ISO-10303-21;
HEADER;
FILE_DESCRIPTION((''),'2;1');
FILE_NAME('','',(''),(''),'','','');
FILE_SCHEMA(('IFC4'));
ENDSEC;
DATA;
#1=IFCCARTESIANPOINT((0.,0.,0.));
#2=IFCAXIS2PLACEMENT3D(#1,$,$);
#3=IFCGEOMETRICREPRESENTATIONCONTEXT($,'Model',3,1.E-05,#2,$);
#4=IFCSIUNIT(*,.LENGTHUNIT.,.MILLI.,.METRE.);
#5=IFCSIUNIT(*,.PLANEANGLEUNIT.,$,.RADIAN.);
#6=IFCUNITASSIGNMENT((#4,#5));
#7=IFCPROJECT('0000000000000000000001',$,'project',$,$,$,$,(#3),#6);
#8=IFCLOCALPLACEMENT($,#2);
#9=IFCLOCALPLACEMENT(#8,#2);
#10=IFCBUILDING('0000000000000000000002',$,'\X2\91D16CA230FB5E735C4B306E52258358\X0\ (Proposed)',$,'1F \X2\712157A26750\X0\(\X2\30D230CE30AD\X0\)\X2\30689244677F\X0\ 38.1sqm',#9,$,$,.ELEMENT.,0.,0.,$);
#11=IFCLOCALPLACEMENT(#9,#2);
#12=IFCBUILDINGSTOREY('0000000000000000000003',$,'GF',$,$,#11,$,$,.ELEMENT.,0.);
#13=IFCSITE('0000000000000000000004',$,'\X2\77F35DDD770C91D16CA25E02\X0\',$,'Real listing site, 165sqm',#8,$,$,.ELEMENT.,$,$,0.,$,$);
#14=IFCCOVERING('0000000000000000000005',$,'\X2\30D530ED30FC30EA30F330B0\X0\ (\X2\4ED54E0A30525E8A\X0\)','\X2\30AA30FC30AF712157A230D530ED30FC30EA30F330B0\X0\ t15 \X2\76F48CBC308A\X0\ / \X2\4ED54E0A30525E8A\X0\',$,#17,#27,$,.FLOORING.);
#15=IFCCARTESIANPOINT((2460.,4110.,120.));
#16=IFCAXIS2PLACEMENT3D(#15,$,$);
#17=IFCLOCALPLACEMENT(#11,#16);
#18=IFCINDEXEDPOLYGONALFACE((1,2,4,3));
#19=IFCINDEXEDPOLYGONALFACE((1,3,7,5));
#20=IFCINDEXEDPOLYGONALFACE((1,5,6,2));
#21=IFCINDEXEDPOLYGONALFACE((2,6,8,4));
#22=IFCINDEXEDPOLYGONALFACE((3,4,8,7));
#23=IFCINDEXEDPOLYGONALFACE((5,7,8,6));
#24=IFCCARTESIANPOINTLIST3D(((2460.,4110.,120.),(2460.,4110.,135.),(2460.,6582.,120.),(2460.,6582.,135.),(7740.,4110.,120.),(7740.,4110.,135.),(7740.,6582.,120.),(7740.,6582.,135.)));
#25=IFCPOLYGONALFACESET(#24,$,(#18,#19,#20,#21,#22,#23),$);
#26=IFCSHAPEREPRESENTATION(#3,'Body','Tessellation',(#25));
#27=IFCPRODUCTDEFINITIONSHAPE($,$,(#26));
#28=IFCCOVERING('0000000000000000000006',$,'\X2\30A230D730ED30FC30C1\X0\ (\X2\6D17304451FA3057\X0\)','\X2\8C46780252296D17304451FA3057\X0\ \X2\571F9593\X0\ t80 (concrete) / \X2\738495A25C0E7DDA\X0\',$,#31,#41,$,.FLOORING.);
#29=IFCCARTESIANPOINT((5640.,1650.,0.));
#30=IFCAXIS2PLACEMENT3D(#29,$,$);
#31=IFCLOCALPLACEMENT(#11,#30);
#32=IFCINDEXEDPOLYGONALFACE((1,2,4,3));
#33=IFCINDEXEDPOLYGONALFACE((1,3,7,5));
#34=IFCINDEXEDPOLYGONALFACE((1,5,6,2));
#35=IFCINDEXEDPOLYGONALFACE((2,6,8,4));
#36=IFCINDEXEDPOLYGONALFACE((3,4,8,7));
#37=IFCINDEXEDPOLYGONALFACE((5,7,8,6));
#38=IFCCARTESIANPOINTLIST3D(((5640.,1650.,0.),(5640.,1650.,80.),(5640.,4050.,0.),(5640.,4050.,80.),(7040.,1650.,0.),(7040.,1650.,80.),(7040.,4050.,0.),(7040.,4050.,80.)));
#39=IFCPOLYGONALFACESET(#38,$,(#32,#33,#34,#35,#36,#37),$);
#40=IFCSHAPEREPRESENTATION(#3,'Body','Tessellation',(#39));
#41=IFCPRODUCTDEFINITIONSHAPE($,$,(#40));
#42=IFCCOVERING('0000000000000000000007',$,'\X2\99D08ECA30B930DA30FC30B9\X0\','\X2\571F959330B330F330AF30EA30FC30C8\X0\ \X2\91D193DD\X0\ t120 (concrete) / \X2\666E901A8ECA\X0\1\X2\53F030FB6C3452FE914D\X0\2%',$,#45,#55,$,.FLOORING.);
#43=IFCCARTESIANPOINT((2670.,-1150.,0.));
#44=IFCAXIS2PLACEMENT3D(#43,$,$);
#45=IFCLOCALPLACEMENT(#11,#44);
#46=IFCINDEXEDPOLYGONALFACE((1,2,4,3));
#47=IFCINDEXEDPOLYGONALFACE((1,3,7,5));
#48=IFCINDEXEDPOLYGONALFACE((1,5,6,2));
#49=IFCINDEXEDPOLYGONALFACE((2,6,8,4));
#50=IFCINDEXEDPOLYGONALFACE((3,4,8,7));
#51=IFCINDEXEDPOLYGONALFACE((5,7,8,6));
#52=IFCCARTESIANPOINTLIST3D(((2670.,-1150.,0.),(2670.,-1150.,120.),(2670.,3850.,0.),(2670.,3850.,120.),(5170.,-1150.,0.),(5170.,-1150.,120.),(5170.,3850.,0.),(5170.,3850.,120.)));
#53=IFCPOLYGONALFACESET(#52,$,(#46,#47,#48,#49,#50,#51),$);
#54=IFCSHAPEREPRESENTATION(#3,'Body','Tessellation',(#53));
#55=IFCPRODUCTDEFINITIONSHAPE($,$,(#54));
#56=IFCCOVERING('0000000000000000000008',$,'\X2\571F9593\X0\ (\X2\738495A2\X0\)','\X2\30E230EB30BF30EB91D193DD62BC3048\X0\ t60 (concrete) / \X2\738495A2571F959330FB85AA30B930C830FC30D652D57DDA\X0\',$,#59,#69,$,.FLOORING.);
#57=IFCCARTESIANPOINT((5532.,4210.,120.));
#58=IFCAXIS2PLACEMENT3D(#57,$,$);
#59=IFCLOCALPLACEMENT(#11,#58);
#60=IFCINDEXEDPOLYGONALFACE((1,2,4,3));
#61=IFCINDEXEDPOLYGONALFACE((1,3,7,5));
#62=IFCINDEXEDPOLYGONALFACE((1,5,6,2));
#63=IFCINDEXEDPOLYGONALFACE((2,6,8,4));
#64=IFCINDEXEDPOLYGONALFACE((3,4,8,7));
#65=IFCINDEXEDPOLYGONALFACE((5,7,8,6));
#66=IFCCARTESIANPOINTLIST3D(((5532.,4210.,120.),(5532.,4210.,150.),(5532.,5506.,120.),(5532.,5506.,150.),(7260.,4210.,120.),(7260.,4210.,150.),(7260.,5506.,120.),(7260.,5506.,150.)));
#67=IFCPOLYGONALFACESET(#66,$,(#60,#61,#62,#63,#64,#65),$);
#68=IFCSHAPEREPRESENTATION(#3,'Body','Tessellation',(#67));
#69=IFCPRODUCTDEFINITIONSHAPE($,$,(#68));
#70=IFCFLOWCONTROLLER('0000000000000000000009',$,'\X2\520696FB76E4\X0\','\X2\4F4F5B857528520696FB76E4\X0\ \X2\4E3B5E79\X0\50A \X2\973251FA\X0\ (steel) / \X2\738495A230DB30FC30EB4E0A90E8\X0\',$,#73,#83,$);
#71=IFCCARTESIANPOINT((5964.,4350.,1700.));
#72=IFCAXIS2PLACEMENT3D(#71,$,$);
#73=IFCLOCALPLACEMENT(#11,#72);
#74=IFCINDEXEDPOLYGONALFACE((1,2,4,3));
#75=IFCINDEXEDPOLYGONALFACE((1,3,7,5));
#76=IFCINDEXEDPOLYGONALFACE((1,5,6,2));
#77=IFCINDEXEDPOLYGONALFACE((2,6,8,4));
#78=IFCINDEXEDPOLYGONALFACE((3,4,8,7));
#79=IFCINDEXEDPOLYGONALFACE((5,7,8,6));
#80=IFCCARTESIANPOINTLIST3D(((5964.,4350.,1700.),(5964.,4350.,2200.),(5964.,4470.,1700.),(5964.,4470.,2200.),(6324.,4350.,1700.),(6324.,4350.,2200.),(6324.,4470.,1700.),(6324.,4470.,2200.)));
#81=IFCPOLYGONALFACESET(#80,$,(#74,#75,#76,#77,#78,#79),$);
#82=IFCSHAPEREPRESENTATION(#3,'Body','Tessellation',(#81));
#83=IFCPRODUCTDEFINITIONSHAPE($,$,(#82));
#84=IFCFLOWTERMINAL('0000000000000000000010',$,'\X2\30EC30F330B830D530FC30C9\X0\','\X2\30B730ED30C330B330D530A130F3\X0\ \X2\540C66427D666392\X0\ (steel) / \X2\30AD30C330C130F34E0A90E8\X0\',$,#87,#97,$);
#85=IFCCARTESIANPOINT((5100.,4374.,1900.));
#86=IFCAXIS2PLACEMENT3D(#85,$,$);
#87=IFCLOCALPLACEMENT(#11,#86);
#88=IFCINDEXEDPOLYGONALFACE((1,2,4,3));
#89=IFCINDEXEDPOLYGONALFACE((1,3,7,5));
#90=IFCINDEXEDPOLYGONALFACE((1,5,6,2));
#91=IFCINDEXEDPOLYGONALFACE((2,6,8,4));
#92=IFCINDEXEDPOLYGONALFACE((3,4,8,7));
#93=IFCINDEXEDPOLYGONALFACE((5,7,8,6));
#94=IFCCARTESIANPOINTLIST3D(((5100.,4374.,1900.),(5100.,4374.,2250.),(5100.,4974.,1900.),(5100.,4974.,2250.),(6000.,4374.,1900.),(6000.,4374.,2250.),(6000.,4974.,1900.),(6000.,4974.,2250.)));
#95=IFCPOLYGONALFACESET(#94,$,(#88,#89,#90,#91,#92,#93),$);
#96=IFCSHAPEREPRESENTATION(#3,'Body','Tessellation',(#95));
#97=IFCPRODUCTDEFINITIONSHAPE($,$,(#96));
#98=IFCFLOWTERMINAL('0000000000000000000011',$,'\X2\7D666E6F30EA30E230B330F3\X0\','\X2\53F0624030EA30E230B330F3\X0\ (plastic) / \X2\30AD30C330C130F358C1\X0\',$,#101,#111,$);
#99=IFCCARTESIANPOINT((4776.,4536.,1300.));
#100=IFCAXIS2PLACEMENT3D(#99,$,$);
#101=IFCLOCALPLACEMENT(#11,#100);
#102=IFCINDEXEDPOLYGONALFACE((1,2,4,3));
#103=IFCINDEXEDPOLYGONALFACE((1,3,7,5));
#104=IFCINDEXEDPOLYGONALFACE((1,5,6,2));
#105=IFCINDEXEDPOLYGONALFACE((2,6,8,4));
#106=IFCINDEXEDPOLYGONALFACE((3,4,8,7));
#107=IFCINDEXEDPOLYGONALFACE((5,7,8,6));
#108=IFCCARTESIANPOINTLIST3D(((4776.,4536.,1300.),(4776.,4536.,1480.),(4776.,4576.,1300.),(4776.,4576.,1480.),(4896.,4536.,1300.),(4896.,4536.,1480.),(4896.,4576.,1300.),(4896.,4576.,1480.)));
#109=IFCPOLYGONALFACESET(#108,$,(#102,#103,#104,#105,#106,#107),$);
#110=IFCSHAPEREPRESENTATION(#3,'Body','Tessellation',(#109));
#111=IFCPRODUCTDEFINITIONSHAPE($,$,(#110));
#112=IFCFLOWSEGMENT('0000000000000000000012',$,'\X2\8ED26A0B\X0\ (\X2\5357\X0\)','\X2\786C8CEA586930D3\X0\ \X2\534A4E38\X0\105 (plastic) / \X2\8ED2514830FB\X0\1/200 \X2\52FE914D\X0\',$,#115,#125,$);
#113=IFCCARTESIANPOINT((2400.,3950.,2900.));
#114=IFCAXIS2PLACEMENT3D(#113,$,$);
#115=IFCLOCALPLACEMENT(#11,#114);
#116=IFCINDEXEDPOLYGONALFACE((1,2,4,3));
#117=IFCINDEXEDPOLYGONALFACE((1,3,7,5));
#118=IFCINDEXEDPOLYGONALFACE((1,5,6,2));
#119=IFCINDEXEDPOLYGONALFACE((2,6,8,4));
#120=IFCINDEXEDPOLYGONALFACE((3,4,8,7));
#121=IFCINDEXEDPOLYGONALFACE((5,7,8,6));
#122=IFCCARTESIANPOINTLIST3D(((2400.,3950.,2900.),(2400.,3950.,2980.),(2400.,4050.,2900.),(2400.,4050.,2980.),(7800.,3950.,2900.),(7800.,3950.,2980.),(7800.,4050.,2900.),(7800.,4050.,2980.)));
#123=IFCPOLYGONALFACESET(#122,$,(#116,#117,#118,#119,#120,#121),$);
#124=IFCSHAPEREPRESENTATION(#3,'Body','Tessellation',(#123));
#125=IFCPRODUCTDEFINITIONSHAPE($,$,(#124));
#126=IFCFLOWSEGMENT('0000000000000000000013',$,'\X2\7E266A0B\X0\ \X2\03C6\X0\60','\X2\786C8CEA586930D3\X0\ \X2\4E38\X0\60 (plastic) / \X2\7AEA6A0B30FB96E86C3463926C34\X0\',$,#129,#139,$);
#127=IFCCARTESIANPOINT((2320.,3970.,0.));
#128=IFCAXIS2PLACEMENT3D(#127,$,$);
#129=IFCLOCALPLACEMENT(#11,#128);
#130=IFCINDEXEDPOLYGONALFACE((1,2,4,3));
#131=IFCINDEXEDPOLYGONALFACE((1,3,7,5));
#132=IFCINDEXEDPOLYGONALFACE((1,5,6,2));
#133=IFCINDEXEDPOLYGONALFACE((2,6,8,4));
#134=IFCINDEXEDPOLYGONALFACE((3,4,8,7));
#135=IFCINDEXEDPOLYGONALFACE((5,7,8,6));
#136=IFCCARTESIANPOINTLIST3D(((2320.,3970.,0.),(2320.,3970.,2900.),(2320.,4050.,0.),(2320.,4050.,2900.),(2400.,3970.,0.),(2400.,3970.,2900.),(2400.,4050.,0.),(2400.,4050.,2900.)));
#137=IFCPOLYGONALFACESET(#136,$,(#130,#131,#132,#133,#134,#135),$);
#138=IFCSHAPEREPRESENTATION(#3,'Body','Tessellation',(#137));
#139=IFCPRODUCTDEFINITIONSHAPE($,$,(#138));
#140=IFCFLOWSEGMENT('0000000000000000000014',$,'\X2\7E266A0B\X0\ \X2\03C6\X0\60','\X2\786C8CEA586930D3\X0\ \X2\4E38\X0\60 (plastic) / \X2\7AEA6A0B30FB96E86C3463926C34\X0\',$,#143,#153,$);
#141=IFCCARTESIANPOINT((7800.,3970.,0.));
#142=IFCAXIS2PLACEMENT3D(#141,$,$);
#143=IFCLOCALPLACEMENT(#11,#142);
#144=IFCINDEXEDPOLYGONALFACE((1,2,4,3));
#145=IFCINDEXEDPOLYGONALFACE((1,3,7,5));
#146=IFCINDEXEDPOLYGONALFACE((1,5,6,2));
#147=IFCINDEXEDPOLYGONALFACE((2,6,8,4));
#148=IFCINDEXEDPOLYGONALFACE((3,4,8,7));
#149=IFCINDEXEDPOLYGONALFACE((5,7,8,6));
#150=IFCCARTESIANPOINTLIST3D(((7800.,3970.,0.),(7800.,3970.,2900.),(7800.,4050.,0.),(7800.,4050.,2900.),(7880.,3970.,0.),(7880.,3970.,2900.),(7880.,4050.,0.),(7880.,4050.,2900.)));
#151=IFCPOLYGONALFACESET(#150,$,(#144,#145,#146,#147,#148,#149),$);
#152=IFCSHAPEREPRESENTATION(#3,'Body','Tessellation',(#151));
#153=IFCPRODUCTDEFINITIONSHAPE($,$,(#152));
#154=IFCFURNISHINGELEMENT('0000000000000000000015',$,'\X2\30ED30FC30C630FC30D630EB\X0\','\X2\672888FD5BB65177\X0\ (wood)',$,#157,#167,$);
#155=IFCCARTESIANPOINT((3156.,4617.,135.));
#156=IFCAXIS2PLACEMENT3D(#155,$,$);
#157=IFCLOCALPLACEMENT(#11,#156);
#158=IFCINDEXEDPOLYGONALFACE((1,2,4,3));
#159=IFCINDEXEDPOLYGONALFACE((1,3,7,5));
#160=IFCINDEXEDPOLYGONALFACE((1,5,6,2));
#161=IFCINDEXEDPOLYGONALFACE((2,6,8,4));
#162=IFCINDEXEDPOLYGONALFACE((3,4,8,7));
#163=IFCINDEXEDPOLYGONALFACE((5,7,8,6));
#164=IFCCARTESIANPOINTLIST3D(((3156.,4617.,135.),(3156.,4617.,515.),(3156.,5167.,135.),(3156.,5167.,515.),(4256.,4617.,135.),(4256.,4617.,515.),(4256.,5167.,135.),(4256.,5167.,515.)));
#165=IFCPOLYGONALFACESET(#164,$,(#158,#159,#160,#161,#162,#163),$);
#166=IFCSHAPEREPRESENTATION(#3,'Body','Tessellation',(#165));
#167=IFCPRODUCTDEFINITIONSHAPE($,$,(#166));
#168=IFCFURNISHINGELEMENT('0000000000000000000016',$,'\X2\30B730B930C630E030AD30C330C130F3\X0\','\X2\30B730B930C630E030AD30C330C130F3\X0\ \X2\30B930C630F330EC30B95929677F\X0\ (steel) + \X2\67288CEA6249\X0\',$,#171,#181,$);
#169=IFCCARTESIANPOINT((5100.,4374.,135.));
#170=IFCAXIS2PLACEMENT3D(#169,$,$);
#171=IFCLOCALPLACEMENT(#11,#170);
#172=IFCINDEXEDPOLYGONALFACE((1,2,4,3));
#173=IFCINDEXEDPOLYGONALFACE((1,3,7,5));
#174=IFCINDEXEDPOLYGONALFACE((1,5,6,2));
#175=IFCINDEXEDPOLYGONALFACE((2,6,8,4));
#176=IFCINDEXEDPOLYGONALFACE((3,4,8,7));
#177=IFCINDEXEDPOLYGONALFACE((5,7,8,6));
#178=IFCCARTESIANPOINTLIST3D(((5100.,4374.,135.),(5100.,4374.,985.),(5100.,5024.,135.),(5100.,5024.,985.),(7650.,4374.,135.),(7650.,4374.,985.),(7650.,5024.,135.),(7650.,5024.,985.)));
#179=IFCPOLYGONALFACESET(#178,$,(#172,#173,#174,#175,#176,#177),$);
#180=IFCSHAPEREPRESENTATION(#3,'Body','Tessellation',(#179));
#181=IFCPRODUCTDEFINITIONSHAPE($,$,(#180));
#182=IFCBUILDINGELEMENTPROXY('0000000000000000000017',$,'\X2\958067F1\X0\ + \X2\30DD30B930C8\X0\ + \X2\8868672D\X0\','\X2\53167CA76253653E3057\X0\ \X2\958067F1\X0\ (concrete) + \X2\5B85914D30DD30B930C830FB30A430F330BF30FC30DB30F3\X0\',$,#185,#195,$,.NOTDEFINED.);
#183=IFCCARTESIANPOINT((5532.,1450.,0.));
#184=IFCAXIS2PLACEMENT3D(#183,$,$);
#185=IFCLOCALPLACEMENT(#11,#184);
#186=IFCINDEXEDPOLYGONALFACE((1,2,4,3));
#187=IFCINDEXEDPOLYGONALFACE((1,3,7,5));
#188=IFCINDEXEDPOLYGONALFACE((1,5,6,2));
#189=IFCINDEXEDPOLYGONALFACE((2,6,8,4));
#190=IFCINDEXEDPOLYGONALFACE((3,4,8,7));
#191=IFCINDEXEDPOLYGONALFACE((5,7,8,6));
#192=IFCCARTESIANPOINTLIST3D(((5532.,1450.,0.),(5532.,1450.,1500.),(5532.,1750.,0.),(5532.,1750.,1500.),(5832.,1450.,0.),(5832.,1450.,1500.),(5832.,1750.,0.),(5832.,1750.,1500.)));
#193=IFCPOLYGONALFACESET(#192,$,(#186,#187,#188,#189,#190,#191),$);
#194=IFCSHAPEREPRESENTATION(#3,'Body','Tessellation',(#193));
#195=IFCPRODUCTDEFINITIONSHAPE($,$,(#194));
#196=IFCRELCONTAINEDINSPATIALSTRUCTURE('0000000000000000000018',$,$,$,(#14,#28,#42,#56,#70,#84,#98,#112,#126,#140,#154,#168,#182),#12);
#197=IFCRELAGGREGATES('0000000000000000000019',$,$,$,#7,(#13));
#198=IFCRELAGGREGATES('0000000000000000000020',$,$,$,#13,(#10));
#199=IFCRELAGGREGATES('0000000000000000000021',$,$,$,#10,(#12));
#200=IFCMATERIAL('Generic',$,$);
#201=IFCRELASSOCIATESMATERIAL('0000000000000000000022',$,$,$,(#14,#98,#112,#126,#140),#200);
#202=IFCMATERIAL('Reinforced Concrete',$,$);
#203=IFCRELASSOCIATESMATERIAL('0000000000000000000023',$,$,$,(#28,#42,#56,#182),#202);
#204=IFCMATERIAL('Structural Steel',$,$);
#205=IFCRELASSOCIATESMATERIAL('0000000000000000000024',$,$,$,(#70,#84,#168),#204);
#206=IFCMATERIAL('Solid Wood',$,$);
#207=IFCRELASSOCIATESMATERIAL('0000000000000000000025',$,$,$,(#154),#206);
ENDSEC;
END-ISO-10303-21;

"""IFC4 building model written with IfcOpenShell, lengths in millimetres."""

from ifc_helpers import new_model, si_unit, frame, frame_2d, origin, place, context, project, spatial, rectangle, extrude, material, element, save


model = new_model("IFC4")

# Units and contexts
model_context = context("Model", 3, precision=1e-05, world=origin())
ifc_project = project(units=[si_unit("LENGTHUNIT", "METRE", prefix="MILLI"), si_unit("PLANEANGLEUNIT", "RADIAN")], contexts=[model_context])

# Site, building, storey
site_placement = place(None, origin())
site = spatial("IfcSite", under=ifc_project, at=site_placement, Name="石川県金沢市", ObjectType="Real listing site, 165sqm", CompositionType="ELEMENT", RefElevation=0.0)
building_placement = place(site_placement, origin())
building = spatial("IfcBuilding", under=site, at=building_placement, Name="金沢・平屋の別荘 (Proposed)", ObjectType="1F 無垢材(ヒノキ)と鉄板 38.1sqm", CompositionType="ELEMENT", ElevationOfRefHeight=0.0, ElevationOfTerrain=0.0)
storey_placement = place(building_placement, origin())
storey = spatial("IfcBuildingStorey", under=building, at=storey_placement, Name="GF", CompositionType="ELEMENT", Elevation=0.0)

# Shared definitions
ifc_material_1 = material(Name="Solid Wood")

# Shared definitions
ifc_material_2 = material(Name="Reinforced Concrete")

# Shared definitions
ifc_material_3 = material(Name="Structural Steel")

# Coverings
ifc_material_4 = material(Name="Generic")
covering_1_placement = place(storey_placement, frame((2460.0, 4110.0, 120.0)))
element("IfcCovering", 1, at=covering_1_placement, inside=storey, material=ifc_material_4, Name="フローリング (仕上げ床)", Description="オーク無垢フローリング t15 直貼り / 仕上げ床", PredefinedType="FLOORING", context=model_context, shape_type="SweptSolid", body=[
    extrude(rectangle(XDim=5280.0, YDim=2472.0, at=frame_2d((2640.0, 1236.0))), frame((2460.0, 4110.0, 120.0)), (0.0, 0.0, 1.0), 15.0),
])
covering_2_placement = place(storey_placement, frame((5640.0, 1650.0, 0.0)))
element("IfcCovering", 2, at=covering_2_placement, inside=storey, material=ifc_material_2, Name="アプローチ (洗い出し)", Description="豆砂利洗い出し 土間 t80 (concrete) / 玄関導線", PredefinedType="FLOORING", context=model_context, shape_type="SweptSolid", body=[
    extrude(rectangle(XDim=1400.0, YDim=2400.0, at=frame_2d((700.0, 1200.0))), frame((5640.0, 1650.0, 0.0)), (0.0, 0.0, 1.0), 80.0),
])
covering_3_placement = place(storey_placement, frame((2670.0, -1150.0, 0.0)))
element("IfcCovering", 3, at=covering_3_placement, inside=storey, material=ifc_material_2, Name="駐車スペース", Description="土間コンクリート 金鏝 t120 (concrete) / 普通車1台・水勾配2%", PredefinedType="FLOORING", context=model_context, shape_type="SweptSolid", body=[
    extrude(rectangle(XDim=2500.0, YDim=5000.0, at=frame_2d((1250.0, 2500.0))), frame((2670.0, -1150.0, 0.0)), (0.0, 0.0, 1.0), 120.0),
])
covering_4_placement = place(storey_placement, frame((5532.0, 4210.0, 120.0)))
element("IfcCovering", 4, at=covering_4_placement, inside=storey, material=ifc_material_2, Name="土間 (玄関)", Description="モルタル金鏝押え t60 (concrete) / 玄関土間・薪ストーブ動線", PredefinedType="FLOORING", context=model_context, shape_type="SweptSolid", body=[
    extrude(rectangle(XDim=1728.0, YDim=1296.0, at=frame_2d((864.0, 648.0))), frame((5532.0, 4210.0, 120.0)), (0.0, 0.0, 1.0), 30.0),
])

# Flow controller
flow_controller_placement = place(storey_placement, frame((5964.0, 4350.0, 1700.0)))
element("IfcFlowController", 5, at=flow_controller_placement, inside=storey, material=ifc_material_3, Name="分電盤", Description="住宅用分電盤 主幹50A 露出 (steel) / 玄関ホール上部", context=model_context, shape_type="SweptSolid", body=[
    extrude(rectangle(XDim=360.0, YDim=120.0, at=frame_2d((180.0, 60.0))), frame((5964.0, 4350.0, 1700.0)), (0.0, 0.0, 1.0), 500.0),
])

# Flow terminals
flow_terminal_1_placement = place(storey_placement, frame((5100.0, 4374.0, 1900.0)))
element("IfcFlowTerminal", 6, at=flow_terminal_1_placement, inside=storey, material=ifc_material_3, Name="レンジフード", Description="シロッコファン 同時給排 (steel) / キッチン上部", context=model_context, shape_type="SweptSolid", body=[
    extrude(rectangle(XDim=900.0, YDim=600.0, at=frame_2d((450.0, 300.0))), frame((5100.0, 4374.0, 1900.0)), (0.0, 0.0, 1.0), 350.0),
])
flow_terminal_2_placement = place(storey_placement, frame((4776.0, 4536.0, 1300.0)))
element("IfcFlowTerminal", 7, at=flow_terminal_2_placement, inside=storey, material=ifc_material_4, Name="給湯リモコン", Description="台所リモコン (plastic) / キッチン壁", context=model_context, shape_type="SweptSolid", body=[
    extrude(rectangle(XDim=120.0, YDim=40.0, at=frame_2d((60.0, 20.0))), frame((4776.0, 4536.0, 1300.0)), (0.0, 0.0, 1.0), 180.0),
])

# Flow segments
flow_segment_1_placement = place(storey_placement, frame((2400.0, 3950.0, 2900.0)))
element("IfcFlowSegment", 8, at=flow_segment_1_placement, inside=storey, material=ifc_material_4, Name="軒樋 (南)", Description="硬質塩ビ 半丸105 (plastic) / 軒先・1/200 勾配", context=model_context, shape_type="SweptSolid", body=[
    extrude(rectangle(XDim=5400.0, YDim=100.0, at=frame_2d((2700.0, 50.0))), frame((2400.0, 3950.0, 2900.0)), (0.0, 0.0, 1.0), 80.0),
])
flow_segment_2_placement = place(storey_placement, frame((2320.0, 3970.0, 0.0)))
element("IfcFlowSegment", 9, at=flow_segment_2_placement, inside=storey, material=ifc_material_4, Name="縦樋 φ60", Description="硬質塩ビ 丸60 (plastic) / 竪樋・雨水排水", context=model_context, shape_type="SweptSolid", body=[
    extrude(rectangle(XDim=80.0, YDim=80.0, at=frame_2d((40.0, 40.0))), frame((2320.0, 3970.0, 0.0)), (0.0, 0.0, 1.0), 2900.0),
])
flow_segment_3_placement = place(storey_placement, frame((7800.0, 3970.0, 0.0)))
element("IfcFlowSegment", 10, at=flow_segment_3_placement, inside=storey, material=ifc_material_4, Name="縦樋 φ60", Description="硬質塩ビ 丸60 (plastic) / 竪樋・雨水排水", context=model_context, shape_type="SweptSolid", body=[
    extrude(rectangle(XDim=80.0, YDim=80.0, at=frame_2d((40.0, 40.0))), frame((7800.0, 3970.0, 0.0)), (0.0, 0.0, 1.0), 2900.0),
])

# Furnishing elements
furnishing_1_placement = place(storey_placement, frame((3156.0, 4617.0, 135.0)))
element("IfcFurnishingElement", 11, at=furnishing_1_placement, inside=storey, material=ifc_material_1, Name="ローテーブル", Description="木製家具 (wood)", context=model_context, shape_type="SweptSolid", body=[
    extrude(rectangle(XDim=1100.0, YDim=550.0, at=frame_2d((550.0, 275.0))), frame((3156.0, 4617.0, 135.0)), (0.0, 0.0, 1.0), 380.0),
])
furnishing_2_placement = place(storey_placement, frame((5100.0, 4374.0, 135.0)))
element("IfcFurnishingElement", 12, at=furnishing_2_placement, inside=storey, material=ifc_material_3, Name="システムキッチン", Description="システムキッチン ステンレス天板 (steel) + 木質扉", context=model_context, shape_type="SweptSolid", body=[
    extrude(rectangle(XDim=2550.0, YDim=650.0, at=frame_2d((1275.0, 325.0))), frame((5100.0, 4374.0, 135.0)), (0.0, 0.0, 1.0), 850.0),
])

# Building element proxy
proxy_placement = place(storey_placement, frame((5532.0, 1450.0, 0.0)))
element("IfcBuildingElementProxy", 13, at=proxy_placement, inside=storey, material=ifc_material_2, Name="門柱 + ポスト + 表札", Description="化粧打放し 門柱 (concrete) + 宅配ポスト・インターホン", PredefinedType="NOTDEFINED", context=model_context, shape_type="SweptSolid", body=[
    extrude(rectangle(XDim=300.0, YDim=300.0, at=frame_2d((150.0, 150.0))), frame((5532.0, 1450.0, 0.0)), (0.0, 0.0, 1.0), 1500.0),
])

save(model, "model.ifc")
